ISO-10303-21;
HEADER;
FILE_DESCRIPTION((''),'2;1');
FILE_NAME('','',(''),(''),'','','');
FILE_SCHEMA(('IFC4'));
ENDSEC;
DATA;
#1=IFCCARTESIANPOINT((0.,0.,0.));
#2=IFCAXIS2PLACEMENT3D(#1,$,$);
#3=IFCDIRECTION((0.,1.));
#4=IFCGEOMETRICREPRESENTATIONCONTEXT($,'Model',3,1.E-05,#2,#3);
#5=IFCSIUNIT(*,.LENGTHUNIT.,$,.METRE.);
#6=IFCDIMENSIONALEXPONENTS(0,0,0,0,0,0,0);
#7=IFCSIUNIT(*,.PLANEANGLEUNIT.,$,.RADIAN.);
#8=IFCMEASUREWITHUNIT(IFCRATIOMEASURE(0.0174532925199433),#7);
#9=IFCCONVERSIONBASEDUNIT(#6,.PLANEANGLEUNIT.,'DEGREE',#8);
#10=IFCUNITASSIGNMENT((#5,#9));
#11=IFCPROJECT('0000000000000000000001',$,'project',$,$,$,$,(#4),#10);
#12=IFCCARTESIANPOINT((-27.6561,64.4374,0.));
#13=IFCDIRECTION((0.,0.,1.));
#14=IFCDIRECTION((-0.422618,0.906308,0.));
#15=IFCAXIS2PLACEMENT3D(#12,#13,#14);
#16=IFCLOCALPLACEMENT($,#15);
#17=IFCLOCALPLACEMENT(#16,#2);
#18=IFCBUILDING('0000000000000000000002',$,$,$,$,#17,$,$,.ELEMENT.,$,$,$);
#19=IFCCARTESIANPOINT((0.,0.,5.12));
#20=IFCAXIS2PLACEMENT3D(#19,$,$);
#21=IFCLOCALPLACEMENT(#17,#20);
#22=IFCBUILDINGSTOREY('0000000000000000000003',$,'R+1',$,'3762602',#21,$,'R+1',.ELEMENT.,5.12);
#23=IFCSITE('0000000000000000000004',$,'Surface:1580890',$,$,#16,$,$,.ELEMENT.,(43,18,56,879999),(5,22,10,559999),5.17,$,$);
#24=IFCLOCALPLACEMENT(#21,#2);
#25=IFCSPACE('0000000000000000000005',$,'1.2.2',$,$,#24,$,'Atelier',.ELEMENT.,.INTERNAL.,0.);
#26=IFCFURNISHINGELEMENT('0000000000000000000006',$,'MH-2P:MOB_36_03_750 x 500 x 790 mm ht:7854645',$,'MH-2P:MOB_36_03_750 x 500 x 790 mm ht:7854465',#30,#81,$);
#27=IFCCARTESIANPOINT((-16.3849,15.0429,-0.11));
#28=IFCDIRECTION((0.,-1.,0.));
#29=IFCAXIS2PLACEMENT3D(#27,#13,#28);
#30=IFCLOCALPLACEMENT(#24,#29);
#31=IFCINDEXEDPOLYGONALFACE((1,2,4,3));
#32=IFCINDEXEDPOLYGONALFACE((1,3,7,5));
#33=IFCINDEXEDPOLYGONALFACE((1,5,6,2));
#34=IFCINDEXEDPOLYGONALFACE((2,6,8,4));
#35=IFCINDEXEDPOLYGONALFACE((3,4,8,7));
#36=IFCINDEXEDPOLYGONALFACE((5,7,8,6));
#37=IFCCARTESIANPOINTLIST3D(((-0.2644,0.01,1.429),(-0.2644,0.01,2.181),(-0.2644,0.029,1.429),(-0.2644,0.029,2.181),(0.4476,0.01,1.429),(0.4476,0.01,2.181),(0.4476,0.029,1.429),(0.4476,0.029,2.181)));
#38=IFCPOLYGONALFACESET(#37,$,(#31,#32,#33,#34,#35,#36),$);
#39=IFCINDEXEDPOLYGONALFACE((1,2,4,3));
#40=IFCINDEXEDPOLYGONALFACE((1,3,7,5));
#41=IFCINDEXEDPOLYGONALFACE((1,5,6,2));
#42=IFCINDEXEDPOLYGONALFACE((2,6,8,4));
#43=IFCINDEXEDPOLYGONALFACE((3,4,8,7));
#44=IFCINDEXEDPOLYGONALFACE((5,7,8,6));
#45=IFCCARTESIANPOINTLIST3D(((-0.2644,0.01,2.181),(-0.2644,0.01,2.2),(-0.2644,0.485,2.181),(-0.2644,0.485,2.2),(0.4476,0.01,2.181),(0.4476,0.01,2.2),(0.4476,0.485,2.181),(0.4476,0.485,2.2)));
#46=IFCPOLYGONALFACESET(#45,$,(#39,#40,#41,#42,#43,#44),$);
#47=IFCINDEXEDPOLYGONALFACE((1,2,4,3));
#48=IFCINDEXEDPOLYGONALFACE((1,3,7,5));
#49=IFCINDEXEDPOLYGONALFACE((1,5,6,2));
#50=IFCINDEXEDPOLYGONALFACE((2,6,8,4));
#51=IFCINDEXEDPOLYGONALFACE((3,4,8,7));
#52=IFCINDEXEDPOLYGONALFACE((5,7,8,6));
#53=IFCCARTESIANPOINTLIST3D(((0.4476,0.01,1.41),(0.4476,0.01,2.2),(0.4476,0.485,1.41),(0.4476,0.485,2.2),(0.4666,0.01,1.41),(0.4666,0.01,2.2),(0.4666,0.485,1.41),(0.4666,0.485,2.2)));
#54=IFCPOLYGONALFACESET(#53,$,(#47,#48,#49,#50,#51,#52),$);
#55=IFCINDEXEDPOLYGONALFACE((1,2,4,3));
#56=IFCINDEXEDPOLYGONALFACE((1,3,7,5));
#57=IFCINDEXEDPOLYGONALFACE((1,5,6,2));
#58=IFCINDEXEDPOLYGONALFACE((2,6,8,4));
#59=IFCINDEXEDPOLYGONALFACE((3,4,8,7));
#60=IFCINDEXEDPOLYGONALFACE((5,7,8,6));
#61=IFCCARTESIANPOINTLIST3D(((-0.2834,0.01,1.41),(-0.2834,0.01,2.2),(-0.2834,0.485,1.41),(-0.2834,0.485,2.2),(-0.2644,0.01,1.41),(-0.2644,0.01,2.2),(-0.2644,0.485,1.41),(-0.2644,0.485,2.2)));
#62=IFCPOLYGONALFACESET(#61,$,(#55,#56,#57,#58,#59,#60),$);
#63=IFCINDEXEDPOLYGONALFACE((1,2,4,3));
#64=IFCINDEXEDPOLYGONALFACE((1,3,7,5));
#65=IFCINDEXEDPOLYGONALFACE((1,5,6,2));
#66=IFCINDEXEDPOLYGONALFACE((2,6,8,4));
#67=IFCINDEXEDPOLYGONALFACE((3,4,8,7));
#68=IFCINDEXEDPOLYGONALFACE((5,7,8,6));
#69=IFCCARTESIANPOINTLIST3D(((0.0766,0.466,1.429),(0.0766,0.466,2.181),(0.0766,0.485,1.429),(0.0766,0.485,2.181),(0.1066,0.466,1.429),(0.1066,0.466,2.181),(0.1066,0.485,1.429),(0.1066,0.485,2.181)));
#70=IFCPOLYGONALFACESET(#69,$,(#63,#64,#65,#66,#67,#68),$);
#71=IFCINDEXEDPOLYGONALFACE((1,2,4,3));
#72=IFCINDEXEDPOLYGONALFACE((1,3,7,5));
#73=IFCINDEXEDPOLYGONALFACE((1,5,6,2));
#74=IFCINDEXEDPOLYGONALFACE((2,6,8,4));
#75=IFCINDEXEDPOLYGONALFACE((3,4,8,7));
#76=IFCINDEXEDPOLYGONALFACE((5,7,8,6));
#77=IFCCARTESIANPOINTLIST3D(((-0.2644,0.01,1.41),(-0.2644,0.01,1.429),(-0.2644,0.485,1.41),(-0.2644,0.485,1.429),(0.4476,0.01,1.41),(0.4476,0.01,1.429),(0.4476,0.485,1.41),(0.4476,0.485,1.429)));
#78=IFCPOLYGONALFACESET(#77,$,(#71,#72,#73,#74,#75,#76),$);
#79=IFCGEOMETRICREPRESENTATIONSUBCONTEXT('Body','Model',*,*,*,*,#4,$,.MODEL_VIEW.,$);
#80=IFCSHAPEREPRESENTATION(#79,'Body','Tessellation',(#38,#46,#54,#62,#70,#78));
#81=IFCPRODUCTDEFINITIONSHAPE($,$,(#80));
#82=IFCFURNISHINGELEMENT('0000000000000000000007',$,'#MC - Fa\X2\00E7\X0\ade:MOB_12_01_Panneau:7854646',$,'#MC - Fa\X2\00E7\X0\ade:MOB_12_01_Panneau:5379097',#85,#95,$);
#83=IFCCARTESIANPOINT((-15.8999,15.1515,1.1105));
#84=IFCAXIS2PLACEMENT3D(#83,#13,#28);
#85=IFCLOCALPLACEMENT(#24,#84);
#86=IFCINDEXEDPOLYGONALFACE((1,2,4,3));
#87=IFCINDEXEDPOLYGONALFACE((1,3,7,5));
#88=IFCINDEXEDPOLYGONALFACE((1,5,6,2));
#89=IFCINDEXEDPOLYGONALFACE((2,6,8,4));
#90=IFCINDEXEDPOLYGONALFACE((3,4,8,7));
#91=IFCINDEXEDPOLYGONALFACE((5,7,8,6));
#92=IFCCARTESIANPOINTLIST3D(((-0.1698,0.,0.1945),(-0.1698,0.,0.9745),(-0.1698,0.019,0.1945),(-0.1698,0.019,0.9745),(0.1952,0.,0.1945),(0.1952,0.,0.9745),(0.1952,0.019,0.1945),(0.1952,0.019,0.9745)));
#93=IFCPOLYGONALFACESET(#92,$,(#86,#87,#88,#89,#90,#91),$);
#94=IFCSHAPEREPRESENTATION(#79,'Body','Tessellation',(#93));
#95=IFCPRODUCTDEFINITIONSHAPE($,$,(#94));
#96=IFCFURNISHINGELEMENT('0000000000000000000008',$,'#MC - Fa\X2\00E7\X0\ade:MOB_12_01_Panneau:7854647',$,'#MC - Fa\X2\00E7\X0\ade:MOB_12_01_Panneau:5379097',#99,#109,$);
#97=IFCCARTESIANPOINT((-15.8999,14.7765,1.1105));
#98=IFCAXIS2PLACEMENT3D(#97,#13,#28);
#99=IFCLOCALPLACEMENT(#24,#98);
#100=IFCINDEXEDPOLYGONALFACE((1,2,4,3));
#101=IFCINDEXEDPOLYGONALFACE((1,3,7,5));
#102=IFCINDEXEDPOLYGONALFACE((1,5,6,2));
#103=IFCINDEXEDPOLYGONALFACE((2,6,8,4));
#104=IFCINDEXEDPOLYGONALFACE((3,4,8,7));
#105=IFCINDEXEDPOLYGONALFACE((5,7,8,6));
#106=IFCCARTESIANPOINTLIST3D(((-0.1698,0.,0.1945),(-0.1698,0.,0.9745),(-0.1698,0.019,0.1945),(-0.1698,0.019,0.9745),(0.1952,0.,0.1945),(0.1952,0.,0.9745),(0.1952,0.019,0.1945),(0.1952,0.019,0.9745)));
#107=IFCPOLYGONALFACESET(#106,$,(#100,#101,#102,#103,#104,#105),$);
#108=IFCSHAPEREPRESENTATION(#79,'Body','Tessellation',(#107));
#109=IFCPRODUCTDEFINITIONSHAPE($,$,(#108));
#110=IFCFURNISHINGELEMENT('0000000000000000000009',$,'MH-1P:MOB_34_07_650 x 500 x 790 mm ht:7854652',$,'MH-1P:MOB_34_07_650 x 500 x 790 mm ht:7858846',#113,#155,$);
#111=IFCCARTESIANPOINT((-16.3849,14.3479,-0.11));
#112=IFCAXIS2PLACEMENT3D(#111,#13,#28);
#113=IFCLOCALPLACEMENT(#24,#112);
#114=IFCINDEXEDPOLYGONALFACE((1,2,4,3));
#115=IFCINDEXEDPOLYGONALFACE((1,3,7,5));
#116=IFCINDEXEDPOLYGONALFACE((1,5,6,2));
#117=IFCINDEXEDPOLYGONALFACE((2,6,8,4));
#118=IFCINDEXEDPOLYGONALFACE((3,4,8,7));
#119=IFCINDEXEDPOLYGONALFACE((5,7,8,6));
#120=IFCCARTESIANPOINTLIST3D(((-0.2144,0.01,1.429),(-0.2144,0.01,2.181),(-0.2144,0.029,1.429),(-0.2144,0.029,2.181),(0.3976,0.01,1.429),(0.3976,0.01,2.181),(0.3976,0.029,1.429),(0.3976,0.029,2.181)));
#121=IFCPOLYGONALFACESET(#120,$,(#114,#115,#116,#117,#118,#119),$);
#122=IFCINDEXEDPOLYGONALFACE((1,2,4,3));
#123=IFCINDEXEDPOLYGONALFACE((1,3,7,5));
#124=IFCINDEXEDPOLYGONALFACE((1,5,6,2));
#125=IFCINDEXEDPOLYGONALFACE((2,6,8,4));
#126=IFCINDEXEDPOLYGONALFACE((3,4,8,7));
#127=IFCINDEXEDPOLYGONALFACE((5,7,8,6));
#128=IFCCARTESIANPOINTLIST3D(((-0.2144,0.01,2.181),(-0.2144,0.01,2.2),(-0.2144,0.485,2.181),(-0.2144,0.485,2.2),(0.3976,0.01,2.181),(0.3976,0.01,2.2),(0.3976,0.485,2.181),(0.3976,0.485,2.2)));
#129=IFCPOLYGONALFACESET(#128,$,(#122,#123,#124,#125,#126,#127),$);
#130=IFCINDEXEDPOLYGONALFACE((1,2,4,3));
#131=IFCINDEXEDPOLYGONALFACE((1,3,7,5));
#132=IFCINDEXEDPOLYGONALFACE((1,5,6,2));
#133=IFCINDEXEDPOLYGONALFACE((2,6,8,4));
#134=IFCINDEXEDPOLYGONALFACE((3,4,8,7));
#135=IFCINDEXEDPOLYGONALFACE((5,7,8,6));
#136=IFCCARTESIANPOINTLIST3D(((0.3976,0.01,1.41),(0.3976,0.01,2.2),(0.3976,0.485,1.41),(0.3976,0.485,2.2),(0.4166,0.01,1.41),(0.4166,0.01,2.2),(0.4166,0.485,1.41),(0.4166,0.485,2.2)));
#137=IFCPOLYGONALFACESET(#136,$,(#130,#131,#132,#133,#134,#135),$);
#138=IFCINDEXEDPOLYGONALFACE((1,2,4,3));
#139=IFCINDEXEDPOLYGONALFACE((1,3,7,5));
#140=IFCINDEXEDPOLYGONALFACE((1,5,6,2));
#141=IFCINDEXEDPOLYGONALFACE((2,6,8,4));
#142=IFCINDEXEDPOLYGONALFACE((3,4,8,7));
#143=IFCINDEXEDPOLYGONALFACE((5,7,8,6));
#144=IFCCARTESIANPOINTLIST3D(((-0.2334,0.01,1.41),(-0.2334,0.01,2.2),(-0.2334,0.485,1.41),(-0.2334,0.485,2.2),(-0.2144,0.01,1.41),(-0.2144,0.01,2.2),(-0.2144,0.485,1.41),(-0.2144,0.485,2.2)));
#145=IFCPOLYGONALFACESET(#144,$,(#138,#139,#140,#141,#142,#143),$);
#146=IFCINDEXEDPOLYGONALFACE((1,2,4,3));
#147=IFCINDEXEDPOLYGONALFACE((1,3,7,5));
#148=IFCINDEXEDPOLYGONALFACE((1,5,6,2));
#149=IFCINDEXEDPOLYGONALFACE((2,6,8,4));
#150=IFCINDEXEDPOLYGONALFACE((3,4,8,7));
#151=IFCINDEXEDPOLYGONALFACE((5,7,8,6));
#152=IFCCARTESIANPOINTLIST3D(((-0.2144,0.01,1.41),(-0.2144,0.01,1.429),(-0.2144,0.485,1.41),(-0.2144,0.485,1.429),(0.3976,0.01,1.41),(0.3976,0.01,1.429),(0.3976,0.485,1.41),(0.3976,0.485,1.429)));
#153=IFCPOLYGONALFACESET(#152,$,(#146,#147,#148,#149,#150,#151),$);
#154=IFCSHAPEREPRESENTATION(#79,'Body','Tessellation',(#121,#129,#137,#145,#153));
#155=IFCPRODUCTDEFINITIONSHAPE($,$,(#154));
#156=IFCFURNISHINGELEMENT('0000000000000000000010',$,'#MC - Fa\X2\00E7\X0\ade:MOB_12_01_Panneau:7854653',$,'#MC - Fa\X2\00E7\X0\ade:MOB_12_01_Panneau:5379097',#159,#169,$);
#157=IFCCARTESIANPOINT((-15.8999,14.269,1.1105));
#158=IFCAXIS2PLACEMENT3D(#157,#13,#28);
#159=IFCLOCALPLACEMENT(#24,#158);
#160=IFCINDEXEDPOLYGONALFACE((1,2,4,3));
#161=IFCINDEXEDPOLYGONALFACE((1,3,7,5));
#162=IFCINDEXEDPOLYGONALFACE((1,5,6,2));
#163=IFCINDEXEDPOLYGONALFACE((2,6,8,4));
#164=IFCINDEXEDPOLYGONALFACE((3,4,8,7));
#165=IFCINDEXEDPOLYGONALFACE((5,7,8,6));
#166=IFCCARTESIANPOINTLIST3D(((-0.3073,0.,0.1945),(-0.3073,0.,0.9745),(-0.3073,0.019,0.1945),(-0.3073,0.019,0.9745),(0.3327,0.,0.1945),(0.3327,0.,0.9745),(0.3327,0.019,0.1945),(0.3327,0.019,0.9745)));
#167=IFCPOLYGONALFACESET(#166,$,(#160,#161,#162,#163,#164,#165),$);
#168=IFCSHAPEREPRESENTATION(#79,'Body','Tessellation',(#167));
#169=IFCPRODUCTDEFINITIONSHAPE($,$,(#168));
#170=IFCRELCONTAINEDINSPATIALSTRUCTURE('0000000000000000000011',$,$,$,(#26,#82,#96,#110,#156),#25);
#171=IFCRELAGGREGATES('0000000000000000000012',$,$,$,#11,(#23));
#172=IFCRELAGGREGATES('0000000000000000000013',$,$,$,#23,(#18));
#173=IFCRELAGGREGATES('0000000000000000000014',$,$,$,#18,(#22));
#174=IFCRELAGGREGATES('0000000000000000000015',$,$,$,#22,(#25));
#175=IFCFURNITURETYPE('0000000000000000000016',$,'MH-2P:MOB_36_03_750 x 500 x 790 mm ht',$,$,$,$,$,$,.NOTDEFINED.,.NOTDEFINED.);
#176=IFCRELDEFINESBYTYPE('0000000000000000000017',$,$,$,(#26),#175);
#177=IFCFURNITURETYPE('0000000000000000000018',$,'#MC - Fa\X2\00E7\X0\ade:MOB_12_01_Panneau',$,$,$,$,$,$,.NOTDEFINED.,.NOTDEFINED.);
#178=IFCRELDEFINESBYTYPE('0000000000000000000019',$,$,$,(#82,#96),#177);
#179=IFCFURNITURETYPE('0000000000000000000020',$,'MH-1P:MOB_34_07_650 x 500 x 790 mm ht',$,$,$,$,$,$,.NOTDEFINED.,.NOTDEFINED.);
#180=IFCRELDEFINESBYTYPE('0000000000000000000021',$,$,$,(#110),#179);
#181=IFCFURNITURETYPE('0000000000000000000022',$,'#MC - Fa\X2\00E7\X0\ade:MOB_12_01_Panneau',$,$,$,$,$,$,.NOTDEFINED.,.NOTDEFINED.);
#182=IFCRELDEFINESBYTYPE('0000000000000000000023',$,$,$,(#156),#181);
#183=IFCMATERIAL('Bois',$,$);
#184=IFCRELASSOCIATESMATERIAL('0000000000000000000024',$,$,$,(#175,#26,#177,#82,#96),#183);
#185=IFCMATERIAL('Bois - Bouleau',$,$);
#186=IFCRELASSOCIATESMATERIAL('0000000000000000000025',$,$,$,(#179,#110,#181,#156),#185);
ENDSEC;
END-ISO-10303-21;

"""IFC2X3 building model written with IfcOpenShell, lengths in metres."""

from ifc_helpers import new_model, entity, si_unit, converted_unit, direction, frame, frame_2d, origin, origin_2d_with_axis, place, context, subcontext, project, spatial, rectangle, extrude, source, transform, mapped, material, type_object, type_shapes, element, save


model = new_model("IFC2X3")

# Units and contexts
model_context = context("Model", 3, precision=1e-05, world=origin(), true_north=direction((0.0, 1.0)))
body_context = subcontext(model_context, "Body", "Model", "MODEL_VIEW")
ifc_project = project(units=[si_unit("LENGTHUNIT", "METRE"), converted_unit("PLANEANGLEUNIT", "DEGREE", entity("IfcRatioMeasure", 0.0174532925199433), si_unit("PLANEANGLEUNIT", "RADIAN"), dimensions=[0, 0, 0, 0, 0, 0, 0])], contexts=[model_context])

# Site, building, storey
site_placement = place(None, frame((-27.6561, 64.4374, 0.0), z_axis=(0.0, 0.0, 1.0), x_axis=(-0.422618, 0.906308, 0.0)))
site = spatial("IfcSite", under=ifc_project, at=site_placement, Name="Surface:1580890", CompositionType="ELEMENT", RefLatitude=(43, 18, 56, 879999), RefLongitude=(5, 22, 10, 559999), RefElevation=5.17)
building_placement = place(site_placement, origin())
building = spatial("IfcBuilding", under=site, at=building_placement, CompositionType="ELEMENT")
storey_placement = place(building_placement, frame((0.0, 0.0, 5.12)))
storey = spatial("IfcBuildingStorey", under=building, at=storey_placement, Name="R+1", ObjectType="3762602", LongName="R+1", CompositionType="ELEMENT", Elevation=5.12)

# Shared definitions
space_placement = place(storey_placement, origin())
space = spatial("IfcSpace", under=storey, at=space_placement, Name="1.2.2", LongName="Atelier", CompositionType="ELEMENT", InteriorOrExteriorSpace="INTERNAL", ElevationWithFlooring=0.0)

# Furnishing elements
ifc_material_1 = material(Name="Bois")
furniture_type_1 = type_object("IfcFurnitureType", Name="MH-2P:MOB_36_03_750 x 500 x 790 mm ht", material=ifc_material_1)
shared_shape_1 = source(origin(), body_context, "Body", "SweptSolid", [
    extrude(rectangle(XDim=0.019, YDim=0.712, at=origin_2d_with_axis()), frame((0.0916, 0.0195, 1.429), z_axis=(0.0, 0.0, 1.0), x_axis=(0.0, 1.0, 0.0)), (0.0, 0.0, 1.0), 0.752),
    extrude(rectangle(XDim=0.475, YDim=0.712, at=frame_2d((0.0, 0.0), x_axis=(1.0, 0.0))), frame((0.0916, 0.2475, 2.181), z_axis=(0.0, 0.0, 1.0), x_axis=(0.0, 1.0, 0.0)), (0.0, 0.0, 1.0), 0.019),
    extrude(rectangle(XDim=0.475, YDim=0.019, at=origin_2d_with_axis()), frame((0.4571, 0.2475, 1.41), z_axis=(0.0, 0.0, 1.0), x_axis=(0.0, 1.0, 0.0)), (0.0, 0.0, 1.0), 0.79),
    extrude(rectangle(XDim=0.475, YDim=0.019, at=origin_2d_with_axis()), frame((-0.2739, 0.2475, 1.41), z_axis=(0.0, 0.0, 1.0), x_axis=(0.0, 1.0, 0.0)), (0.0, 0.0, 1.0), 0.79),
    extrude(rectangle(XDim=0.019, YDim=0.03, at=frame_2d((0.0, 0.0), x_axis=(1.0, 0.0))), frame((0.0916, 0.4755, 1.429), z_axis=(0.0, 0.0, 1.0), x_axis=(0.0, 1.0, 0.0)), (0.0, 0.0, 1.0), 0.752),
    extrude(rectangle(XDim=0.475, YDim=0.712, at=frame_2d((0.0, 0.0), x_axis=(1.0, 0.0))), frame((0.0916, 0.2475, 1.41), z_axis=(0.0, 0.0, 1.0), x_axis=(0.0, 1.0, 0.0)), (0.0, 0.0, 1.0), 0.019),
])
type_shapes(furniture_type_1, [shared_shape_1])
furnishing_1_placement = place(space_placement, frame((-16.3849, 15.0429, -0.11), z_axis=(0.0, 0.0, 1.0), x_axis=(0.0, -1.0, 0.0)))
element("IfcFurnishingElement", 1, at=furnishing_1_placement, inside=space, type_object=furniture_type_1, material=ifc_material_1, Name="MH-2P:MOB_36_03_750 x 500 x 790 mm ht:7854645", ObjectType="MH-2P:MOB_36_03_750 x 500 x 790 mm ht:7854465", context=body_context, shape_type="MappedRepresentation", body=[
    mapped(shared_shape_1, transform((0.0, 0.0, 0.0), scale=1.0)),
])
furniture_type_2 = type_object("IfcFurnitureType", Name="#MC - Façade:MOB_12_01_Panneau", material=ifc_material_1)
shared_shape_2 = source(origin(), body_context, "Body", "SweptSolid", [
    extrude(rectangle(XDim=0.019, YDim=0.365, at=origin_2d_with_axis()), frame((0.0127, 0.0095, 0.1945), z_axis=(0.0, 0.0, 1.0), x_axis=(0.0, 1.0, 0.0)), (0.0, 0.0, 1.0), 0.78),
])
type_shapes(furniture_type_2, [shared_shape_2])
for number, where, z_axis, x_axis, name in (
    (2, (-15.8999, 15.1515, 1.1105), (0.0, 0.0, 1.0), (0.0, -1.0, 0.0), "#MC - Façade:MOB_12_01_Panneau:7854646"),
    (3, (-15.8999, 14.7765, 1.1105), (0.0, 0.0, 1.0), (0.0, -1.0, 0.0), "#MC - Façade:MOB_12_01_Panneau:7854647"),
):
    element("IfcFurnishingElement", number, at=place(space_placement, frame(where, z_axis=z_axis, x_axis=x_axis)), inside=space, type_object=furniture_type_2, material=ifc_material_1, Name=name, ObjectType="#MC - Façade:MOB_12_01_Panneau:5379097", context=body_context, shape_type="MappedRepresentation", body=[
        mapped(shared_shape_2, transform((0.0, 0.0, 0.0), scale=1.0)),
    ])
ifc_material_2 = material(Name="Bois - Bouleau")
furniture_type_3 = type_object("IfcFurnitureType", Name="MH-1P:MOB_34_07_650 x 500 x 790 mm ht", material=ifc_material_2)
shared_shape_3 = source(origin(), body_context, "Body", "SweptSolid", [
    extrude(rectangle(XDim=0.612, YDim=0.019, at=origin_2d_with_axis()), frame((0.0916, 0.0195, 1.429)), (0.0, 0.0, 1.0), 0.752),
    extrude(rectangle(XDim=0.475, YDim=0.612, at=frame_2d((0.0, 0.0), x_axis=(1.0, 0.0))), frame((0.0916, 0.2475, 2.181), z_axis=(0.0, 0.0, 1.0), x_axis=(0.0, 1.0, 0.0)), (0.0, 0.0, 1.0), 0.019),
    extrude(rectangle(XDim=0.475, YDim=0.019, at=origin_2d_with_axis()), frame((0.4071, 0.2475, 1.41), z_axis=(0.0, 0.0, 1.0), x_axis=(0.0, 1.0, 0.0)), (0.0, 0.0, 1.0), 0.79),
    extrude(rectangle(XDim=0.475, YDim=0.019, at=origin_2d_with_axis()), frame((-0.2239, 0.2475, 1.41), z_axis=(0.0, 0.0, 1.0), x_axis=(0.0, 1.0, 0.0)), (0.0, 0.0, 1.0), 0.79),
    extrude(rectangle(XDim=0.475, YDim=0.612, at=frame_2d((0.0, 0.0), x_axis=(1.0, 0.0))), frame((0.0916, 0.2475, 1.41), z_axis=(0.0, 0.0, 1.0), x_axis=(0.0, 1.0, 0.0)), (0.0, 0.0, 1.0), 0.019),
])
type_shapes(furniture_type_3, [shared_shape_3])
furnishing_2_placement = place(space_placement, frame((-16.3849, 14.3479, -0.11), z_axis=(0.0, 0.0, 1.0), x_axis=(0.0, -1.0, 0.0)))
element("IfcFurnishingElement", 4, at=furnishing_2_placement, inside=space, type_object=furniture_type_3, material=ifc_material_2, Name="MH-1P:MOB_34_07_650 x 500 x 790 mm ht:7854652", ObjectType="MH-1P:MOB_34_07_650 x 500 x 790 mm ht:7858846", context=body_context, shape_type="MappedRepresentation", body=[
    mapped(shared_shape_3, transform((0.0, 0.0, 0.0), scale=1.0)),
])
furniture_type_4 = type_object("IfcFurnitureType", Name="#MC - Façade:MOB_12_01_Panneau", material=ifc_material_2)
shared_shape_4 = source(origin(), body_context, "Body", "SweptSolid", [
    extrude(rectangle(XDim=0.019, YDim=0.64, at=origin_2d_with_axis()), frame((0.0127, 0.0095, 0.1945), z_axis=(0.0, 0.0, 1.0), x_axis=(0.0, 1.0, 0.0)), (0.0, 0.0, 1.0), 0.78),
])
type_shapes(furniture_type_4, [shared_shape_4])
furnishing_3_placement = place(space_placement, frame((-15.8999, 14.269, 1.1105), z_axis=(0.0, 0.0, 1.0), x_axis=(0.0, -1.0, 0.0)))
element("IfcFurnishingElement", 5, at=furnishing_3_placement, inside=space, type_object=furniture_type_4, material=ifc_material_2, Name="#MC - Façade:MOB_12_01_Panneau:7854653", ObjectType="#MC - Façade:MOB_12_01_Panneau:5379097", context=body_context, shape_type="MappedRepresentation", body=[
    mapped(shared_shape_4, transform((0.0, 0.0, 0.0), scale=1.0)),
])

save(model, "model.ifc")
